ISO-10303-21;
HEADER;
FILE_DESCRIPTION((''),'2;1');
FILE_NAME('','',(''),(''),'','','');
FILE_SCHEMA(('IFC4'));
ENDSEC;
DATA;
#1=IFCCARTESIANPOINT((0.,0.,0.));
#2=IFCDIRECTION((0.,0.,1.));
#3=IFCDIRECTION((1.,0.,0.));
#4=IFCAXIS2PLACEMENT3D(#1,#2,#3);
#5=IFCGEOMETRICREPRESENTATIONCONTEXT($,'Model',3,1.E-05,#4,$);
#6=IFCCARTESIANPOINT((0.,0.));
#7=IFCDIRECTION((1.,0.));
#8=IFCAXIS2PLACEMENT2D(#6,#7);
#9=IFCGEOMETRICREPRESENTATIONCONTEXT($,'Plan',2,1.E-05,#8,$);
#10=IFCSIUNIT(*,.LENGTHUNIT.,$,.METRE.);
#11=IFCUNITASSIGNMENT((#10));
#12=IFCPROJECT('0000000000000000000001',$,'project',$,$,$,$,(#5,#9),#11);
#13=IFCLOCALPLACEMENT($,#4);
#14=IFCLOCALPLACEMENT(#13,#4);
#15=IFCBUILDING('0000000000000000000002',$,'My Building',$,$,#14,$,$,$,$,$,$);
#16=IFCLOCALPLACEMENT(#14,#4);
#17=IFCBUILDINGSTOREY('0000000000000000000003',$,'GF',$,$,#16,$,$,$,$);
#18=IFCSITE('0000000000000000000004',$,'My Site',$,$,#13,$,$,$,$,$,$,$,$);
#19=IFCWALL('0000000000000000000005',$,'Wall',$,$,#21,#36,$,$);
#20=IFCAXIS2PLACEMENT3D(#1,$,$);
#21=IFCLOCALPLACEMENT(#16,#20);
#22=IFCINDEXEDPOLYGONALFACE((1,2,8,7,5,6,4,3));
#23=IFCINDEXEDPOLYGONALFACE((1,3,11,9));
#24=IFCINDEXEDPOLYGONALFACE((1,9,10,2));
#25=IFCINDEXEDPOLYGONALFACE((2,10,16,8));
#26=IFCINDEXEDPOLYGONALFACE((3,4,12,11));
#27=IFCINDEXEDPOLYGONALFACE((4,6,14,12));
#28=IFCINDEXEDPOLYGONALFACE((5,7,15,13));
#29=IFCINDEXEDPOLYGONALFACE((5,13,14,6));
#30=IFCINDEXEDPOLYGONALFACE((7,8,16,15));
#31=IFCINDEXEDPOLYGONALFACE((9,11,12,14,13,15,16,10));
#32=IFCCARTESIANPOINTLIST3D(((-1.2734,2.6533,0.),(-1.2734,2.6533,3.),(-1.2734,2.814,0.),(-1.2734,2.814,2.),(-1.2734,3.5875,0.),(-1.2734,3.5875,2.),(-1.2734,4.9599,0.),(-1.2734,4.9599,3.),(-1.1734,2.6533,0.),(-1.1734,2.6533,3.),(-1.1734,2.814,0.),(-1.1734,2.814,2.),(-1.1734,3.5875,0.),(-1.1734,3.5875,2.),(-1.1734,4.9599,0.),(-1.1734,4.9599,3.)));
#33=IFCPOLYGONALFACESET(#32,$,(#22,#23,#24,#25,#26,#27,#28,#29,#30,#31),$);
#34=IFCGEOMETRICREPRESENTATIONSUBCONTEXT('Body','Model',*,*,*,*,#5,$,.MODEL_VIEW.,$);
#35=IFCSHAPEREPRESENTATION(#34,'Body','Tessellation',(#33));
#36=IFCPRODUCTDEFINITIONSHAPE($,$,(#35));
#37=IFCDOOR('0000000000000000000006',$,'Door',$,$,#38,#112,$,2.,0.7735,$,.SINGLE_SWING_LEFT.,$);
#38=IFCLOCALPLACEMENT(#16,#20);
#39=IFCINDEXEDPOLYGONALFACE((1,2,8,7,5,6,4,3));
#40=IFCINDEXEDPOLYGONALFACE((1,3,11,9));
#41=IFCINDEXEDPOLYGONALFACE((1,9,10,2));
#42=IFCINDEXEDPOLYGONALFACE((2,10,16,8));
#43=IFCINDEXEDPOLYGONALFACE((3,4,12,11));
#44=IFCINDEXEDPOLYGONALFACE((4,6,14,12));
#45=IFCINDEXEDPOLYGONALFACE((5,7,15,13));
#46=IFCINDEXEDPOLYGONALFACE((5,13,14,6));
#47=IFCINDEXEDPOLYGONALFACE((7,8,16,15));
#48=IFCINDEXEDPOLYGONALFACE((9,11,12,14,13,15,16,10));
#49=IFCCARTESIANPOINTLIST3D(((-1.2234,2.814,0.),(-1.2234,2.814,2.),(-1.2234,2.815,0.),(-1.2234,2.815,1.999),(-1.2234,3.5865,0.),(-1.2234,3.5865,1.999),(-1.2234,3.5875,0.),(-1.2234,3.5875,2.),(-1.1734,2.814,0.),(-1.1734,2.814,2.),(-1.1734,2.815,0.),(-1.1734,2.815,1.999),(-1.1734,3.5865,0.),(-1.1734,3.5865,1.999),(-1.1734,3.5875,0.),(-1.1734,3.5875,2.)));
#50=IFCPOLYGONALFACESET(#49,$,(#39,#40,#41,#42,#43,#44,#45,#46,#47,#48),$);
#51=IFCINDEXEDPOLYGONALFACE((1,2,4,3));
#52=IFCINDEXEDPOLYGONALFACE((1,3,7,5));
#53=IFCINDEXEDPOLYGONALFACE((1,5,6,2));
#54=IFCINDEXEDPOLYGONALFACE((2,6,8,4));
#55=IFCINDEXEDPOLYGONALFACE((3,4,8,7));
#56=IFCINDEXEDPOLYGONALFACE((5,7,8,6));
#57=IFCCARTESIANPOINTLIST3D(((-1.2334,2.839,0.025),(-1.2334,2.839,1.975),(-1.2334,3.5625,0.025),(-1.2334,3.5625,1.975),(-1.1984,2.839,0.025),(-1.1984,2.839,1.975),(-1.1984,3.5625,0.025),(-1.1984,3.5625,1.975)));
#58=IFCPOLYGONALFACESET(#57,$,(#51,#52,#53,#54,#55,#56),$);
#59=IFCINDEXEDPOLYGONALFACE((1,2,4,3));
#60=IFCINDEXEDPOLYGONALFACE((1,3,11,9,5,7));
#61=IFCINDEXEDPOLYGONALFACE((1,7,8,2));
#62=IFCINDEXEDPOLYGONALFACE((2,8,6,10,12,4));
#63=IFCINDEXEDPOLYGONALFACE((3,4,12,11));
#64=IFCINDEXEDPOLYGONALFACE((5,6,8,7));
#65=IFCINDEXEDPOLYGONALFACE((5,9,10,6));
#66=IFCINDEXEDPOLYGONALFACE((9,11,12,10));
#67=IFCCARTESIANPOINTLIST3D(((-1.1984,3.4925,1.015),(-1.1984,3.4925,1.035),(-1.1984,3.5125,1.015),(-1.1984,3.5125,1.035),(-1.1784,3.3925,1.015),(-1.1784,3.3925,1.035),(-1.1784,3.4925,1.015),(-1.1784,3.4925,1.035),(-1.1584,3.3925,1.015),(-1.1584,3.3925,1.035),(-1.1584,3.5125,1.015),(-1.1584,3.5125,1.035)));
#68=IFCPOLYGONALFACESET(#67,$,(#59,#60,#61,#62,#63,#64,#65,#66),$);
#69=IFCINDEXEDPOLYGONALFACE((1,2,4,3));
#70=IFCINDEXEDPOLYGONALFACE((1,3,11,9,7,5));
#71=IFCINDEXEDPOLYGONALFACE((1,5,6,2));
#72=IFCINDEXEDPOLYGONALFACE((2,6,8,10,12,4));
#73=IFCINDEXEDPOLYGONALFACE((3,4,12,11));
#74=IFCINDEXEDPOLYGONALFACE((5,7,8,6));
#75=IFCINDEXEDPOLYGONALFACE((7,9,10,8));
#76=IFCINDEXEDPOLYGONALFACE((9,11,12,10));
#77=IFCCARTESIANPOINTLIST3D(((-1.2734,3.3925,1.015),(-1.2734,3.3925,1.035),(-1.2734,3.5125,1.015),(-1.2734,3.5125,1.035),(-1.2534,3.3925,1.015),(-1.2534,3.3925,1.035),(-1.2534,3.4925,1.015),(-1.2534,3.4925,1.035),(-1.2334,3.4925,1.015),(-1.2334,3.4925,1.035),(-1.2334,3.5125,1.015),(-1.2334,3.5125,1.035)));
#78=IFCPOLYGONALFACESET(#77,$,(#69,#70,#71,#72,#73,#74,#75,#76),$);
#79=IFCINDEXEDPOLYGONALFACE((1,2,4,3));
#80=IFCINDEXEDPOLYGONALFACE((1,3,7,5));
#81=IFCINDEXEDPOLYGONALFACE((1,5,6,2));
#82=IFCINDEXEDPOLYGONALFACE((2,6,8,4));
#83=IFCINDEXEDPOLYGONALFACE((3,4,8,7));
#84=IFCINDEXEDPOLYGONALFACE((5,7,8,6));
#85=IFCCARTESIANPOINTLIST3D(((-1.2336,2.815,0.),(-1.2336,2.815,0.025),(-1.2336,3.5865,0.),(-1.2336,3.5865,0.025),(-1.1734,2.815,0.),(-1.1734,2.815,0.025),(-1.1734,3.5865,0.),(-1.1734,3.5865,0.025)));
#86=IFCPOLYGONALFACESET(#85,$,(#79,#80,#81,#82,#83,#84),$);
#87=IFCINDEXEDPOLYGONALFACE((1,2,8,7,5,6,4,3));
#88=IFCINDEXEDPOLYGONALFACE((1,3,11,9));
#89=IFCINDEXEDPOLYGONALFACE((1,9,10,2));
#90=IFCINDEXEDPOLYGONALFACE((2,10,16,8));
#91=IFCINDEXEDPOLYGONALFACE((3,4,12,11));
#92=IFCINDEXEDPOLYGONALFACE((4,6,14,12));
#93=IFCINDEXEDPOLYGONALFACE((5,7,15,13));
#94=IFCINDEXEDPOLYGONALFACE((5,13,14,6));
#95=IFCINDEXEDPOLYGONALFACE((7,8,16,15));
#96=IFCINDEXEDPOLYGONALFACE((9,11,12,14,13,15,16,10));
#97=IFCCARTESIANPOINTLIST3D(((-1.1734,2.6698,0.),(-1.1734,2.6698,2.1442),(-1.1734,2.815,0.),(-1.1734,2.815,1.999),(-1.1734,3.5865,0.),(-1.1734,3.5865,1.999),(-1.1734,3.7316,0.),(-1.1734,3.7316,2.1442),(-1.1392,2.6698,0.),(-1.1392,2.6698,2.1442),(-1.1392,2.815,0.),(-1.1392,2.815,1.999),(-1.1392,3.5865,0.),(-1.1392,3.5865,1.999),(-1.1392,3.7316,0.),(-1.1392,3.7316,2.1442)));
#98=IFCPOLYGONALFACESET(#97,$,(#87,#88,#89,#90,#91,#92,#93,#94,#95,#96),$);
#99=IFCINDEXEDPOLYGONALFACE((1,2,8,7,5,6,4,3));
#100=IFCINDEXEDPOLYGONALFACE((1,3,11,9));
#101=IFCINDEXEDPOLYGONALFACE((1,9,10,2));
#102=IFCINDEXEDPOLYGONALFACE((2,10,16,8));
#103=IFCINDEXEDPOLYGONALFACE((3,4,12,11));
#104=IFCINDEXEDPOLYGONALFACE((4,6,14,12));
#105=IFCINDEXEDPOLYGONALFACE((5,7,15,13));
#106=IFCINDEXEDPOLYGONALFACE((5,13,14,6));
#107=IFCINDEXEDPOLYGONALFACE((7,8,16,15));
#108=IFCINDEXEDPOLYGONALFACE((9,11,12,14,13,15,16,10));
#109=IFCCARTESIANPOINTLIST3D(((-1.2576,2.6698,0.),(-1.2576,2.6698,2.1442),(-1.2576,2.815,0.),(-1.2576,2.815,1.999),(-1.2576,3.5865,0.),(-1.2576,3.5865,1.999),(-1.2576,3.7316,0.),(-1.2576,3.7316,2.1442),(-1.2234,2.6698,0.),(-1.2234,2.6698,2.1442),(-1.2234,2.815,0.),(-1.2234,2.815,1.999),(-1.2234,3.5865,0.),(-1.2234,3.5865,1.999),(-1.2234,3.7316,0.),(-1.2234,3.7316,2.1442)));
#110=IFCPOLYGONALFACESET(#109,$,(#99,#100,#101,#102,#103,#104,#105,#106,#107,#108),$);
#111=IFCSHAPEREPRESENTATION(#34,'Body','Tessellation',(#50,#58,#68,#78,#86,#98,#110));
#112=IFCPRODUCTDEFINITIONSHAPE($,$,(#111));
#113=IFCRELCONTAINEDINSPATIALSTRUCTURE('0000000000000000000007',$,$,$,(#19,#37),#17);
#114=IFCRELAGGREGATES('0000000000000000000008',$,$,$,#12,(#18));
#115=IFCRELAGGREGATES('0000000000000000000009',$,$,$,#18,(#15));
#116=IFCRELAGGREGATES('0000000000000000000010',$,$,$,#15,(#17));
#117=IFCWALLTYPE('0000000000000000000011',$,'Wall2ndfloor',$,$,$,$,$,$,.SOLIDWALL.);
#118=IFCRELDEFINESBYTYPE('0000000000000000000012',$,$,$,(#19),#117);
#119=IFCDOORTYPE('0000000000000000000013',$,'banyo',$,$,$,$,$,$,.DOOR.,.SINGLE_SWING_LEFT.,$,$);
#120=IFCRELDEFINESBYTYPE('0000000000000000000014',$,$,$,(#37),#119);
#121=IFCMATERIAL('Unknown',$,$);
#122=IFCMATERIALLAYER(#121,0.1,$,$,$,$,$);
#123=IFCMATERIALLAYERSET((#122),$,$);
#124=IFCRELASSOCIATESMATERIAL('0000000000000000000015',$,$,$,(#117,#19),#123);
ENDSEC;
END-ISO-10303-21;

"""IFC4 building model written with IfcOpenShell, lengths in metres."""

from ifc_helpers import new_model, entity, si_unit, frame, origin_with_axes, origin_2d_with_axis, place, context, subcontext, project, spatial, line, indexed_curve, outline, extrude, shape, source, transform, mapped, material, layer, layer_set, layer_usage, type_object, type_shapes, element, fill, save


model = new_model("IFC4")

# Units and contexts
model_context = context("Model", 3, precision=1e-05, world=origin_with_axes())
plan_context = context("Plan", 2, precision=1e-05, world=origin_2d_with_axis())
body_context_1 = subcontext(model_context, "Body", "Model", "MODEL_VIEW")
body_context_2 = subcontext(plan_context, "Body", "Plan", "PLAN_VIEW")
ifc_project = project(units=[si_unit("LENGTHUNIT", "METRE")], contexts=[model_context, plan_context])

# Site, building, storey
site_placement = place(None, origin_with_axes())
site = spatial("IfcSite", under=ifc_project, at=site_placement, Name="My Site")
building_placement = place(site_placement, origin_with_axes())
building = spatial("IfcBuilding", under=site, at=building_placement, Name="My Building")
storey_placement = place(building_placement, origin_with_axes())
storey = spatial("IfcBuildingStorey", under=building, at=storey_placement, Name="GF")

# Shared definitions
ifc_material = material(Name="Unknown")

# Shared definitions
ifc_layer = layer(ifc_material, 0.1)
ifc_layer_set = layer_set([ifc_layer])
wall_type = type_object("IfcWallType", Name="Wall2ndfloor", PredefinedType="SOLIDWALL", material=ifc_layer_set)

# Wall, opening, door
ifc_layer_usage_1 = layer_usage(ifc_layer_set, "AXIS2", "POSITIVE", 0.0)
wall_1_placement = place(storey_placement, frame((-1.1734, 2.6533, 0.0), z_axis=(0.0, 0.0, 1.0), x_axis=(0.0, 1.0, 0.0)))
wall_1 = element("IfcWall", 1, at=wall_1_placement, inside=storey, type_object=wall_type, material=ifc_layer_usage_1, Name="Wall", context=body_context_1, shape_type="SweptSolid", body=[
    extrude(outline(indexed_curve([(0.0, 0.0), (0.0, 0.1), (2.3066, 0.1), (2.3066, 0.0)], segments=[line(1, 2, 3, 4, 1)])), origin_with_axes(), (0.0, 0.0, 1.0), 3.0),
])
shared_shape_1 = source(origin_with_axes(), body_context_1, "Body", "SweptSolid", [
    extrude(outline(indexed_curve([(0.0, 0.0), (0.7735, 0.0), (0.7735, 2.0), (0.0, 2.0)], segments=[line(1, 2, 3, 4, 1)])), frame((0.0, -0.6, 0.0), z_axis=(0.0, -1.0, 0.0), x_axis=(1.0, 0.0, 0.0)), (0.0, 0.0, -1.0), 1.2),
])
opening_1_placement = place(wall_1_placement, frame((0.1607, 0.0, 0.0), z_axis=(0.0, 0.0, 1.0), x_axis=(1.0, 0.0, 0.0)))
opening_1 = element("IfcOpeningElement", 2, at=opening_1_placement, cuts=wall_1, PredefinedType="OPENING", context=body_context_1, shape_type="MappedRepresentation", body=[
    mapped(shared_shape_1, transform((0.0, 0.0, 0.0), x_axis=(1.0, 0.0, 0.0), y_axis=(0.0, 1.0, 0.0), z_axis=(0.0, 0.0, 1.0), scale=1.0)),
])
door_type_1 = type_object("IfcDoorType", Name="banyo", OperationType="SINGLE_SWING_LEFT", PredefinedType="DOOR")
shared_shape_2 = source(origin_with_axes(), body_context_1, "Body", "SweptSolid", [
    extrude(outline(indexed_curve([(0.0, 0.0), (0.0, 2.0), (0.7735, 2.0), (0.7735, 0.0), (0.7725, 0.0), (0.7725, 1.999), (0.001, 1.999), (0.001, 0.0)], segments=[line(1, 2, 3, 4, 5, 6, 7, 8, 1)])), frame((0.0, 0.0, 0.0), z_axis=(0.0, -1.0, 0.0), x_axis=(1.0, 0.0, 0.0)), (0.0, 0.0, -1.0), 0.05),
    extrude(outline(indexed_curve([(0.0, 0.0), (0.7235, 0.0), (0.7235, 0.035), (0.0, 0.035)], segments=[line(1, 2, 3, 4, 1)])), frame((0.025, 0.025, 0.025), z_axis=(0.0, 0.0, 1.0), x_axis=(1.0, 0.0, 0.0)), (0.0, 0.0, 1.0), 1.95),
    extrude(outline(indexed_curve([(0.0, 0.0), (0.0, -0.04), (-0.12, -0.04), (-0.12, -0.02), (-0.02, -0.02), (-0.02, 0.0)], segments=[line(1, 2, 3, 4, 5, 6, 1)])), frame((0.6985, 0.025, 1.015), z_axis=(0.0, 0.0, 1.0), x_axis=(1.0, 0.0, 0.0)), (0.0, 0.0, 1.0), 0.02),
    extrude(outline(indexed_curve([(0.0, 0.0), (0.0, 0.04), (-0.12, 0.04), (-0.12, 0.02), (-0.02, 0.02), (-0.02, 0.0)], segments=[line(1, 2, 3, 4, 5, 6, 1)])), frame((0.6985, 0.06, 1.015), z_axis=(0.0, 0.0, 1.0), x_axis=(1.0, 0.0, 0.0)), (0.0, 0.0, 1.0), 0.02),
    extrude(outline(indexed_curve([(0.0, 0.0), (0.7715, 0.0), (0.7715, 0.0602), (0.0, 0.0602)], segments=[line(1, 2, 3, 4, 1)])), frame((0.001, 0.0, 0.0), z_axis=(0.0, 0.0, 1.0), x_axis=(1.0, 0.0, 0.0)), (0.0, 0.0, 1.0), 0.025),
    extrude(outline(indexed_curve([(0.0, 0.0), (0.0, 2.1442), (1.0618, 2.1442), (1.0618, 0.0), (0.9167, 0.0), (0.9167, 1.999), (0.1452, 1.999), (0.1452, 0.0)], segments=[line(1, 2, 3, 4, 5, 6, 7, 8, 1)])), frame((-0.1442, -0.0342, 0.0), z_axis=(0.0, -1.0, 0.0), x_axis=(1.0, 0.0, 0.0)), (0.0, 0.0, -1.0), 0.0342),
    extrude(outline(indexed_curve([(0.0, 0.0), (0.0, 2.1442), (1.0618, 2.1442), (1.0618, 0.0), (0.9167, 0.0), (0.9167, 1.999), (0.1452, 1.999), (0.1452, 0.0)], segments=[line(1, 2, 3, 4, 5, 6, 7, 8, 1)])), frame((-0.1442, 0.05, 0.0), z_axis=(0.0, -1.0, 0.0), x_axis=(1.0, 0.0, 0.0)), (0.0, 0.0, -1.0), 0.0342),
])
shared_shape_3 = source(origin_with_axes(), body_context_2, "Body", "Curve2D", [
    entity("IfcIndexedPolyCurve", entity("IfcCartesianPointList2D", [[0.0, 0.0], [0.001, 0.0], [0.001, 0.05], [0.0, 0.05]]), [entity("IfcLineIndex", [1, 2, 3, 4, 1])]),
    entity("IfcIndexedPolyCurve", entity("IfcCartesianPointList2D", [[0.7735, 0.0], [0.7725, 0.0], [0.7725, 0.05], [0.7735, 0.05]]), [entity("IfcLineIndex", [1, 2, 3, 4, 1])]),
    entity("IfcTrimmedCurve", entity("IfcEllipse", entity("IfcAxis2Placement2D", entity("IfcCartesianPoint", [0.06, 0.05]), entity("IfcDirection", [1.0, 0.0])), 0.6885, 0.7235), [entity("IfcCartesianPoint", [0.7485, 0.05])], [entity("IfcCartesianPoint", [0.06, 0.7735])], True, "CARTESIAN"),
    entity("IfcIndexedPolyCurve", entity("IfcCartesianPointList2D", [[0.025, 0.05], [0.06, 0.05], [0.06, 0.7735], [0.025, 0.7735]]), [entity("IfcLineIndex", [1, 2, 3, 4, 1])]),
])
type_shapes(door_type_1, [shared_shape_2, shared_shape_3])
door_1_placement = place(opening_1_placement, frame((0.0, 0.0, 0.0), z_axis=(0.0, 0.0, 1.0), x_axis=(1.0, 0.0, 0.0)))
door_1 = element("IfcDoor", 3, at=door_1_placement, inside=storey, type_object=door_type_1, Name="Door", OperationType="SINGLE_SWING_LEFT", OverallHeight=2.0, OverallWidth=0.7735, shapes=[
    shape(body_context_1, "Body", "MappedRepresentation", [mapped(shared_shape_2, transform((0.0, 0.0, 0.0), x_axis=(1.0, 0.0, 0.0), y_axis=(0.0, 1.0, 0.0), z_axis=(0.0, 0.0, 1.0), scale=1.0))]),
    shape(body_context_2, "Body", "MappedRepresentation", [mapped(shared_shape_3, transform((0.0, 0.0, 0.0), x_axis=(1.0, 0.0, 0.0), y_axis=(0.0, 1.0, 0.0), z_axis=(0.0, 0.0, 1.0), scale=1.0))]),
])
fill(opening_1, door_1)

save(model, "model.ifc")
